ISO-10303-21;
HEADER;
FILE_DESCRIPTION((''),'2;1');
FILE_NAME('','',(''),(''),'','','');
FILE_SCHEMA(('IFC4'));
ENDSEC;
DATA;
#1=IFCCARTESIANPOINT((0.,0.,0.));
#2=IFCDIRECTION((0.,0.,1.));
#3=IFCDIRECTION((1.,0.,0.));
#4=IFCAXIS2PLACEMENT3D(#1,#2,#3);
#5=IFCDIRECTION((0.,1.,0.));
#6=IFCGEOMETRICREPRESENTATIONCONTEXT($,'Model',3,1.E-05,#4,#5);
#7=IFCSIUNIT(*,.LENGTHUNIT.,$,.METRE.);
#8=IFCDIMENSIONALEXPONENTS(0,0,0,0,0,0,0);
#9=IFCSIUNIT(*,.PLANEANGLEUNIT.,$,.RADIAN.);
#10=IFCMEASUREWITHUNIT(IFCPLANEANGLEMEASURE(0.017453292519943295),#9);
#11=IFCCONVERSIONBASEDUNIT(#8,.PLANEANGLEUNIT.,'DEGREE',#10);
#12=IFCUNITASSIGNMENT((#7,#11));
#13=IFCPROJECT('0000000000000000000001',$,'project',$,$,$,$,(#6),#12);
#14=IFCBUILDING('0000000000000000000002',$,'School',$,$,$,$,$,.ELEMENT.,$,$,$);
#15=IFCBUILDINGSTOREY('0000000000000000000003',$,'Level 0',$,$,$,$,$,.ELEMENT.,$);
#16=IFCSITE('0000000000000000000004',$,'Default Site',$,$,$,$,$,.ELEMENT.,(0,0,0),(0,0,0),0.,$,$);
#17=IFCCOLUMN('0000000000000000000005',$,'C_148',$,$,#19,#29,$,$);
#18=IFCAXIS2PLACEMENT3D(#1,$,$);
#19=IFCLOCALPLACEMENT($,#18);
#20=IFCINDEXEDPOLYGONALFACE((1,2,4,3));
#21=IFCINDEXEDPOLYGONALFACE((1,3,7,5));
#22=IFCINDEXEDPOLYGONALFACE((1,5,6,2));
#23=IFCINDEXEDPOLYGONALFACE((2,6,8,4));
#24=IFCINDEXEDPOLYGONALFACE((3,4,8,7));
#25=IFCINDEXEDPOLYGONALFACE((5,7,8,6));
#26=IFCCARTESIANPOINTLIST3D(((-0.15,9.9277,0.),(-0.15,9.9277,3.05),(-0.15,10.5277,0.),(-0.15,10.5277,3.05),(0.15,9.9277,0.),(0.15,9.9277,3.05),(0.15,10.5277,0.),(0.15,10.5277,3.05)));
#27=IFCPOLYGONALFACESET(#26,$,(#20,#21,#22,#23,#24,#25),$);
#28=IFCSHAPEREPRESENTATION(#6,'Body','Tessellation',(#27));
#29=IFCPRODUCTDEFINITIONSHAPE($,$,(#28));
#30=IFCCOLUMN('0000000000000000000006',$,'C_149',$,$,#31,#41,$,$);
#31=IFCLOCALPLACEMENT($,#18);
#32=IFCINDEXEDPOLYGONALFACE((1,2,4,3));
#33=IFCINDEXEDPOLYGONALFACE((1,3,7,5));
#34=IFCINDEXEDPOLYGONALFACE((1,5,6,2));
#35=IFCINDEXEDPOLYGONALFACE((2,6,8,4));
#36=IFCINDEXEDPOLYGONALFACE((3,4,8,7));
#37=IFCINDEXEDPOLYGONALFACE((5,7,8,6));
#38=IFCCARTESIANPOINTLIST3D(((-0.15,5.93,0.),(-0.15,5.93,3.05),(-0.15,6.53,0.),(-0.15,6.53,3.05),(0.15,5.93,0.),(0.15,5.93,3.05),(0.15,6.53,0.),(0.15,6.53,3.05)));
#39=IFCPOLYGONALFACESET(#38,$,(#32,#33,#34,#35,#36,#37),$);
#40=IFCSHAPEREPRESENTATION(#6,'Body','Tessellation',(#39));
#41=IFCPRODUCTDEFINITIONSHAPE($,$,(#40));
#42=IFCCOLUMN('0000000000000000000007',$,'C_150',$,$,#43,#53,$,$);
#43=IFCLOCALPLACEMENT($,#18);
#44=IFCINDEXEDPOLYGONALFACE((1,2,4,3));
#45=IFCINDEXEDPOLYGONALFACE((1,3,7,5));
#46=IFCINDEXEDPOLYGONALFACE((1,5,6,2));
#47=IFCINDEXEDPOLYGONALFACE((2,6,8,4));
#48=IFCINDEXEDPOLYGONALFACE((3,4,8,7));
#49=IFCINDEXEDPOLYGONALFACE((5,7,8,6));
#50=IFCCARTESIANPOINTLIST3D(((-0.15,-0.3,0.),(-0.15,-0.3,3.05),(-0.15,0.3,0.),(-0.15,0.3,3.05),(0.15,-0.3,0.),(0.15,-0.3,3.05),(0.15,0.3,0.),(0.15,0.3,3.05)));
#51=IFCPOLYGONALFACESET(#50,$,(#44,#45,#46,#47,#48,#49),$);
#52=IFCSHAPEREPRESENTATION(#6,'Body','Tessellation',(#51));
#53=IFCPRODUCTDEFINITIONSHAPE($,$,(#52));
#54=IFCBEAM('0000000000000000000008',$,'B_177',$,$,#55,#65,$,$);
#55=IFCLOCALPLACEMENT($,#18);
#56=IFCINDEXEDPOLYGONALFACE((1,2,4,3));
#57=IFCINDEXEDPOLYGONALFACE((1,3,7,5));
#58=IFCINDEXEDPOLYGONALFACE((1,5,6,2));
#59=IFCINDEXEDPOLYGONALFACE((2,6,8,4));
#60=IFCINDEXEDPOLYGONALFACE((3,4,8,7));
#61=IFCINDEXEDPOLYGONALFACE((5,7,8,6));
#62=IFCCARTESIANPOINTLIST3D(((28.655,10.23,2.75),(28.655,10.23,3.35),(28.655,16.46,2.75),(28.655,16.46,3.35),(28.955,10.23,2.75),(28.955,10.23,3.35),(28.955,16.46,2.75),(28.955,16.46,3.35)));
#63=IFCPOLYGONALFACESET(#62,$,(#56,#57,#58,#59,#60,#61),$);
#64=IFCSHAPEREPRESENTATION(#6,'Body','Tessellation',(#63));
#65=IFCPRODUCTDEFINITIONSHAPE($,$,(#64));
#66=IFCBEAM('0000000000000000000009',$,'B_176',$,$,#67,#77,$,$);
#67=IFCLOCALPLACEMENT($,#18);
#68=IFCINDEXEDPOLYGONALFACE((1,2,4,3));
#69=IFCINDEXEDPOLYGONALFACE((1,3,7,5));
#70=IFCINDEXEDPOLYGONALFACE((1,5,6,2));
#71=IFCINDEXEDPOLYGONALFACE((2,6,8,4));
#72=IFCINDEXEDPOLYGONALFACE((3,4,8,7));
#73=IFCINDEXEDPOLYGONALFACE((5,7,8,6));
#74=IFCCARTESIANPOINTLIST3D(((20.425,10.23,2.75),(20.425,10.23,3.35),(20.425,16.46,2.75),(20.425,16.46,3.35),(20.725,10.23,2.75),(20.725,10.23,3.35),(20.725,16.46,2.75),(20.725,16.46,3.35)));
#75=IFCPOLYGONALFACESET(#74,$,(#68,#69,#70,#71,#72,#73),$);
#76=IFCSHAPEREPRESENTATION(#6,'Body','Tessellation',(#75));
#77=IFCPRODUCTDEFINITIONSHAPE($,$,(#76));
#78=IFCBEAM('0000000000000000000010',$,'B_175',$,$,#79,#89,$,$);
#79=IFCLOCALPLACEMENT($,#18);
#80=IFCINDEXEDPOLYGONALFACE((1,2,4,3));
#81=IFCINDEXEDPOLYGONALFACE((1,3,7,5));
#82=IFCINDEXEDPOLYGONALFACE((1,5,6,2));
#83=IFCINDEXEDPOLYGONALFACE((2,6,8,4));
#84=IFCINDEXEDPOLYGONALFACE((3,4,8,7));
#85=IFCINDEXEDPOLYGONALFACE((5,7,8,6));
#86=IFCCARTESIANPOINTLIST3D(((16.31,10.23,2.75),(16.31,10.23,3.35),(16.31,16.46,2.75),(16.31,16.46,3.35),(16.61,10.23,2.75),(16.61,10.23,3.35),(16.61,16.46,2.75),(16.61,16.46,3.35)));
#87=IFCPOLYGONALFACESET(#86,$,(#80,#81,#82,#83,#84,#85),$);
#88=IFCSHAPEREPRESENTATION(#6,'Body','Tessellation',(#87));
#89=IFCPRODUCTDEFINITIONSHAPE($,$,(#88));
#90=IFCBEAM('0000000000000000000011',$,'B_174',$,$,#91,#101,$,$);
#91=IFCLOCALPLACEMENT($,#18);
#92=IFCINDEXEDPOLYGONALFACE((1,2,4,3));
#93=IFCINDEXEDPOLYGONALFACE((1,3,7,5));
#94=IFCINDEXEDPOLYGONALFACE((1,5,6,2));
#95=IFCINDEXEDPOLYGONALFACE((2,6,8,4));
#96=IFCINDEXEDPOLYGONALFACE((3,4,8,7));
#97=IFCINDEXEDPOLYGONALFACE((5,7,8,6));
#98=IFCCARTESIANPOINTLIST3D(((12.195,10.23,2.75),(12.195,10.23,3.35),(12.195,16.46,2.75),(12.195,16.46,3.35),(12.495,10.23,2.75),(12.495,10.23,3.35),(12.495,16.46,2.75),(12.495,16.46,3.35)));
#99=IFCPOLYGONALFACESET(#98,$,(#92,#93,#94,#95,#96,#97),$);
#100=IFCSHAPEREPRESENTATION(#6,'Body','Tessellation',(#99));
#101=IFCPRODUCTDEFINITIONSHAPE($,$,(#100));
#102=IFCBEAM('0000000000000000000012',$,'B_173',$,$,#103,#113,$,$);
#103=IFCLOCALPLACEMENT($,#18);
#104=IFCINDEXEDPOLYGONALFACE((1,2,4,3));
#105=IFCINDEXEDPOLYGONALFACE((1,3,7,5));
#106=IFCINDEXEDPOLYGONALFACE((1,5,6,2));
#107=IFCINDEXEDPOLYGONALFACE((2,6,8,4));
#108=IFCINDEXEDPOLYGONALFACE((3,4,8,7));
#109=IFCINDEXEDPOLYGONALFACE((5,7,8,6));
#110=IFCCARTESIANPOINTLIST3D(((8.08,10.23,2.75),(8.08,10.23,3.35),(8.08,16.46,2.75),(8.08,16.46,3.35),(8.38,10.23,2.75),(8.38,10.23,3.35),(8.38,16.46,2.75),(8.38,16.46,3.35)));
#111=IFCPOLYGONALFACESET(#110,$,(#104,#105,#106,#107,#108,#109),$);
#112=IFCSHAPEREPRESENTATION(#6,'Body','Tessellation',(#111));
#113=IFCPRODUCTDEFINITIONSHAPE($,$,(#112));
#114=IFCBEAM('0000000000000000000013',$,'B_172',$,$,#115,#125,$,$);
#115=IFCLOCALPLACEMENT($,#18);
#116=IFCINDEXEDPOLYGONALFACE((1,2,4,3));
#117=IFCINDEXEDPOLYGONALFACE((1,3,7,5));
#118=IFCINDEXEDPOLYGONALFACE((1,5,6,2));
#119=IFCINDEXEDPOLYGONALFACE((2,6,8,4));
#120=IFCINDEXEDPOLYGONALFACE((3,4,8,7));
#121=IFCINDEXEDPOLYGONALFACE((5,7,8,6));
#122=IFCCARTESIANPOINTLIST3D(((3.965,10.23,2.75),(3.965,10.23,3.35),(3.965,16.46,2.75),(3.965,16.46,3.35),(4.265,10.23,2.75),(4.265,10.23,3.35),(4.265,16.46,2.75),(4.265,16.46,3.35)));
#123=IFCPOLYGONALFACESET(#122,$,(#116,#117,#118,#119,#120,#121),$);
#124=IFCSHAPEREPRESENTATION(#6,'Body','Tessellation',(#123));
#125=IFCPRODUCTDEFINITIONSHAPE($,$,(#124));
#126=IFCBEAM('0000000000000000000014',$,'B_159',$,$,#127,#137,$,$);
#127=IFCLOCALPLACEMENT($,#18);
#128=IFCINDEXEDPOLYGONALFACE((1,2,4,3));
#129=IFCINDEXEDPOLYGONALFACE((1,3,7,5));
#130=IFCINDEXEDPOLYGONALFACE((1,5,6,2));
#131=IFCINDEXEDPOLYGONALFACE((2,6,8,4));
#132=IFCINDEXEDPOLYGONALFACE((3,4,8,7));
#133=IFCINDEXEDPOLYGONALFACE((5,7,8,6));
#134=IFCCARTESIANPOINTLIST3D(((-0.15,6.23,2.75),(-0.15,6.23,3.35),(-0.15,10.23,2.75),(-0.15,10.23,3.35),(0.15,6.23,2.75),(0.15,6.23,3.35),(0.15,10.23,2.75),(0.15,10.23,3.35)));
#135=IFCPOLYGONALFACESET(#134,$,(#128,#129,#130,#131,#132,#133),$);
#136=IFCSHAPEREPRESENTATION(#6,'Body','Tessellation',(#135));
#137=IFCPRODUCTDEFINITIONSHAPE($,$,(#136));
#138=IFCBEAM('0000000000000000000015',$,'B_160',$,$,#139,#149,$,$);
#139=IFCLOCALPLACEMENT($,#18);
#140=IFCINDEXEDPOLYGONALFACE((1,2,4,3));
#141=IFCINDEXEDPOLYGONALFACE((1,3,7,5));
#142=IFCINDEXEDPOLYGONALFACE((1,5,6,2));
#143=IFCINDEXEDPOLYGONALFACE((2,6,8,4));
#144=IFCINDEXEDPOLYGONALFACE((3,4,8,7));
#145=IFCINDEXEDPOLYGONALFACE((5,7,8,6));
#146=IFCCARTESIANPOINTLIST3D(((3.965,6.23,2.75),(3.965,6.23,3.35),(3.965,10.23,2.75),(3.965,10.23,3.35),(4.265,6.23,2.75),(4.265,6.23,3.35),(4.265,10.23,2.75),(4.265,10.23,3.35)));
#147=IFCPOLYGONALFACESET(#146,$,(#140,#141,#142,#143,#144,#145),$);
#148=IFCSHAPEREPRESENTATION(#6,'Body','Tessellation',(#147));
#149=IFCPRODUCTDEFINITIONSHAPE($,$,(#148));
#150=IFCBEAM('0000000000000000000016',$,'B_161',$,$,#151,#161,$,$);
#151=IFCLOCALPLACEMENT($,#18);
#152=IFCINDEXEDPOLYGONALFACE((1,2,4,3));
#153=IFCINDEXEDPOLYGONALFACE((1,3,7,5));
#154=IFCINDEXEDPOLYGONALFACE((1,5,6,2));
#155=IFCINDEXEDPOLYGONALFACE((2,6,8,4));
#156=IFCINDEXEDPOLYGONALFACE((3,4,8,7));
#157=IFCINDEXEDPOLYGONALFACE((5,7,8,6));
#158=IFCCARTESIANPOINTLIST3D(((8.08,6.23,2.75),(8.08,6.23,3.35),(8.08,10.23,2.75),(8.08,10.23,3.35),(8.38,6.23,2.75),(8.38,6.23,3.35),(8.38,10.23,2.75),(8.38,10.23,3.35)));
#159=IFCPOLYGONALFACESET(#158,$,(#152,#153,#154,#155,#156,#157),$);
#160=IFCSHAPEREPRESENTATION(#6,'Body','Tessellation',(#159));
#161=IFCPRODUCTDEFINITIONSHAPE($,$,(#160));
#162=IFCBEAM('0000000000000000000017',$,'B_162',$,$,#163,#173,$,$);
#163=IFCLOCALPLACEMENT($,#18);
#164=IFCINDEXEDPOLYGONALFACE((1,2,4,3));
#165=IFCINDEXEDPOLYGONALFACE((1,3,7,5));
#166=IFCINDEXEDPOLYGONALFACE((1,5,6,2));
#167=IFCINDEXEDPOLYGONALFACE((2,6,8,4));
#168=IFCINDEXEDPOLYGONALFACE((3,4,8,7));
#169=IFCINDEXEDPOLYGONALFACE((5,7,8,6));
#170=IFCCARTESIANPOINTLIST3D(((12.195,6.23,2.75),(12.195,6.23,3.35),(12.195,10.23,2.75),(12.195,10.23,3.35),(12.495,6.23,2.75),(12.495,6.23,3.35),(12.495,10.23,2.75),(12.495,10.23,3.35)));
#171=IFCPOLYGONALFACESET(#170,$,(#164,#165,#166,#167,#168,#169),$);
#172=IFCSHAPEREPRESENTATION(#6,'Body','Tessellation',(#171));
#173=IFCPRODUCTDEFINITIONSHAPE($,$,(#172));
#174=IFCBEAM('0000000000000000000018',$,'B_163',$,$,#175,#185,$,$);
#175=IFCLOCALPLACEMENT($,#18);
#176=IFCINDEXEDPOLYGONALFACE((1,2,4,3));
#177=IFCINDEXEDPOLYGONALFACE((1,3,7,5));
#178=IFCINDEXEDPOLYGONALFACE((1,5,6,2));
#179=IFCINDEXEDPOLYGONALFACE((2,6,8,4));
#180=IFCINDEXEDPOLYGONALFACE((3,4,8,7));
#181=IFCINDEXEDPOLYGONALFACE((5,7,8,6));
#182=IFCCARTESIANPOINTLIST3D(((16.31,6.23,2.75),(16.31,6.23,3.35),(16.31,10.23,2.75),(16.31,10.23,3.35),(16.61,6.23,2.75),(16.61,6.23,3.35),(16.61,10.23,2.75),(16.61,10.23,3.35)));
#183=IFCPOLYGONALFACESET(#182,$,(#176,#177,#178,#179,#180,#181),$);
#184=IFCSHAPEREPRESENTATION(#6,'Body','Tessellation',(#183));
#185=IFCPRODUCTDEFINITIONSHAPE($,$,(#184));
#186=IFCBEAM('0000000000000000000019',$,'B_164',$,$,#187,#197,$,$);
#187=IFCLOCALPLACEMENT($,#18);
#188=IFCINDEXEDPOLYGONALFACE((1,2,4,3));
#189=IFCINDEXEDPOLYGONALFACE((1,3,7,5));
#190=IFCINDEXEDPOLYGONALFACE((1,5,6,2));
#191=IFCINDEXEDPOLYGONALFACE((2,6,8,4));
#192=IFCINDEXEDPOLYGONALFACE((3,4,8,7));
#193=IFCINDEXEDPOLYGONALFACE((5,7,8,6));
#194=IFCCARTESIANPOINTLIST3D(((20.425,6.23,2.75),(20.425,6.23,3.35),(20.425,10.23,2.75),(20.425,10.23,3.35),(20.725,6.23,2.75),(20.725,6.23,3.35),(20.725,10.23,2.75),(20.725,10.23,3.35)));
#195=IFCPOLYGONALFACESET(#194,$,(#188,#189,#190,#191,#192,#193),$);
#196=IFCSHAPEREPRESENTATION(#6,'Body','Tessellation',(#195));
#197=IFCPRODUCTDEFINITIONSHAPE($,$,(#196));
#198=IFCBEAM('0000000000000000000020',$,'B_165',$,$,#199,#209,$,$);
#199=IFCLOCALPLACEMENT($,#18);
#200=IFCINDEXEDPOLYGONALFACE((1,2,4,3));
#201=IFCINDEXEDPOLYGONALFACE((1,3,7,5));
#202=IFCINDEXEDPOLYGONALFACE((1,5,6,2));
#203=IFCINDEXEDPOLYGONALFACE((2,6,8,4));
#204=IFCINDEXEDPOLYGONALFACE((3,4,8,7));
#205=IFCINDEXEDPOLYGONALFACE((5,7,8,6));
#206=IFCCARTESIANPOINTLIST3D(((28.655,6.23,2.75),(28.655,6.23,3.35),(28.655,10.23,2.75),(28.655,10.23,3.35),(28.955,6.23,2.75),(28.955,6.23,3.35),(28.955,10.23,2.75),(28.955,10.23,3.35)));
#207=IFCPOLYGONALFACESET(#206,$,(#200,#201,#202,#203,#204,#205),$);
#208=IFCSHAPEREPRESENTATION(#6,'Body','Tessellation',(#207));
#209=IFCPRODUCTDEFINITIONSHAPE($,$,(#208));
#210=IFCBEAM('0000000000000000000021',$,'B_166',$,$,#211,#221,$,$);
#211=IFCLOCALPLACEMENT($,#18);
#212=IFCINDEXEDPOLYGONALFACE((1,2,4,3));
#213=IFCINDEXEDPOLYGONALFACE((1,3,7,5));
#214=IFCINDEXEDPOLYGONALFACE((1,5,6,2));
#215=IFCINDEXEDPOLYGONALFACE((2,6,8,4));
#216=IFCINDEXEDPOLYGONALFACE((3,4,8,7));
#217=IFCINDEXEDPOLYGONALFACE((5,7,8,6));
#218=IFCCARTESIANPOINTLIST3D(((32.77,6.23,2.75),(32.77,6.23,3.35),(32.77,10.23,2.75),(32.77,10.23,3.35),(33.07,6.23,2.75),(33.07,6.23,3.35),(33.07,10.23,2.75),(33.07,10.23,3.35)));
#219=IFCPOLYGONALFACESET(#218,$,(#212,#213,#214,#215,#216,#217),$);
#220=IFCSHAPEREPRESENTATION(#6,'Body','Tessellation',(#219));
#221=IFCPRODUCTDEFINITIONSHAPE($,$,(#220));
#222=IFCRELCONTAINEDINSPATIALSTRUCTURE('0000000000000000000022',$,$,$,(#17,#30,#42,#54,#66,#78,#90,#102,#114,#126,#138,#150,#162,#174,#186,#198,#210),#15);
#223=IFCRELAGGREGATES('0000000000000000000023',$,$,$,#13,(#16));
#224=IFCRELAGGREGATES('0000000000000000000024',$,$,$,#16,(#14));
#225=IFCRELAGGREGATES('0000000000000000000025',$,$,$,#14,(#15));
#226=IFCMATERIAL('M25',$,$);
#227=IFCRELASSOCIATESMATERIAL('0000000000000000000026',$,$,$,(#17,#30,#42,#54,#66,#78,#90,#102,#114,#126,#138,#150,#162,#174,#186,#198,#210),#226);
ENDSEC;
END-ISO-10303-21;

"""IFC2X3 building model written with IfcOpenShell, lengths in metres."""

from ifc_helpers import new_model, entity, si_unit, converted_unit, direction, frame, frame_2d, origin_with_axes, place, context, project, spatial, rectangle, extrude, material, element, save


model = new_model("IFC2X3")

# Units and contexts
model_context = context("Model", 3, precision=1e-05, world=origin_with_axes(), true_north=direction((0.0, 1.0, 0.0)))
ifc_project = project(units=[si_unit("LENGTHUNIT", "METRE"), converted_unit("PLANEANGLEUNIT", "DEGREE", entity("IfcPlaneAngleMeasure", 0.017453292519943295), si_unit("PLANEANGLEUNIT", "RADIAN"), dimensions=[0, 0, 0, 0, 0, 0, 0])], contexts=[model_context])

# Site, building, storey
site = spatial("IfcSite", under=ifc_project, Name="Default Site", CompositionType="ELEMENT", RefLatitude=(0, 0, 0), RefLongitude=(0, 0, 0), RefElevation=0.0)
building = spatial("IfcBuilding", under=site, Name="School", CompositionType="ELEMENT")
storey = spatial("IfcBuildingStorey", under=building, Name="Level 0", CompositionType="ELEMENT")

# Columns
ifc_material = material(Name="M25")
placement = place(None, origin_with_axes())
element("IfcColumn", 1, at=placement, inside=storey, material=ifc_material, Name="C_148", context=model_context, shape_type="SweptSolid", body=[
    extrude(rectangle(XDim=0.3, YDim=0.6, at=frame_2d((0.0, 0.0), x_axis=(1.0, 0.0, 0.0))), frame((0.0, 10.2277, 0.0), z_axis=(0.0, 0.0, 1.0), x_axis=(1.0, 0.0, 0.0)), (0.0, 0.0, 1.0), 3.05),
])
element("IfcColumn", 2, at=placement, inside=storey, material=ifc_material, Name="C_149", context=model_context, shape_type="SweptSolid", body=[
    extrude(rectangle(XDim=0.3, YDim=0.6, at=frame_2d((0.0, 0.0), x_axis=(1.0, 0.0, 0.0))), frame((0.0, 6.23, 0.0), z_axis=(0.0, 0.0, 1.0), x_axis=(1.0, 0.0, 0.0)), (0.0, 0.0, 1.0), 3.05),
])
element("IfcColumn", 3, at=placement, inside=storey, material=ifc_material, Name="C_150", context=model_context, shape_type="SweptSolid", body=[
    extrude(rectangle(XDim=0.3, YDim=0.6, at=frame_2d((0.0, 0.0), x_axis=(1.0, 0.0, 0.0))), frame((0.0, 0.0, 0.0), z_axis=(0.0, 0.0, 1.0), x_axis=(1.0, 0.0, 0.0)), (0.0, 0.0, 1.0), 3.05),
])

# Beams
element("IfcBeam", 4, at=placement, inside=storey, material=ifc_material, Name="B_177", context=model_context, shape_type="SweptSolid", body=[
    extrude(rectangle(XDim=0.3, YDim=0.6, at=frame_2d((0.0, 0.0), x_axis=(0.0, 1.0, 0.0))), frame((28.805, 10.23, 3.05), z_axis=(0.0, 1.0, 0.0), x_axis=(0.0, 0.0, -1.0)), (0.0, 0.0, 1.0), 6.23),
])
element("IfcBeam", 5, at=placement, inside=storey, material=ifc_material, Name="B_176", context=model_context, shape_type="SweptSolid", body=[
    extrude(rectangle(XDim=0.3, YDim=0.6, at=frame_2d((0.0, 0.0), x_axis=(0.0, 1.0, 0.0))), frame((20.575, 10.23, 3.05), z_axis=(0.0, 1.0, 0.0), x_axis=(0.0, 0.0, -1.0)), (0.0, 0.0, 1.0), 6.23),
])
element("IfcBeam", 6, at=placement, inside=storey, material=ifc_material, Name="B_175", context=model_context, shape_type="SweptSolid", body=[
    extrude(rectangle(XDim=0.3, YDim=0.6, at=frame_2d((0.0, 0.0), x_axis=(0.0, 1.0, 0.0))), frame((16.46, 10.23, 3.05), z_axis=(0.0, 1.0, 0.0), x_axis=(0.0, 0.0, -1.0)), (0.0, 0.0, 1.0), 6.23),
])
element("IfcBeam", 7, at=placement, inside=storey, material=ifc_material, Name="B_174", context=model_context, shape_type="SweptSolid", body=[
    extrude(rectangle(XDim=0.3, YDim=0.6, at=frame_2d((0.0, 0.0), x_axis=(0.0, 1.0, 0.0))), frame((12.345, 10.23, 3.05), z_axis=(0.0, 1.0, 0.0), x_axis=(0.0, 0.0, -1.0)), (0.0, 0.0, 1.0), 6.23),
])
element("IfcBeam", 8, at=placement, inside=storey, material=ifc_material, Name="B_173", context=model_context, shape_type="SweptSolid", body=[
    extrude(rectangle(XDim=0.3, YDim=0.6, at=frame_2d((0.0, 0.0), x_axis=(0.0, 1.0, 0.0))), frame((8.23, 10.23, 3.05), z_axis=(0.0, 1.0, 0.0), x_axis=(0.0, 0.0, -1.0)), (0.0, 0.0, 1.0), 6.23),
])
element("IfcBeam", 9, at=placement, inside=storey, material=ifc_material, Name="B_172", context=model_context, shape_type="SweptSolid", body=[
    extrude(rectangle(XDim=0.3, YDim=0.6, at=frame_2d((0.0, 0.0), x_axis=(0.0, 1.0, 0.0))), frame((4.115, 10.23, 3.05), z_axis=(0.0, 1.0, 0.0), x_axis=(0.0, 0.0, -1.0)), (0.0, 0.0, 1.0), 6.23),
])
element("IfcBeam", 10, at=placement, inside=storey, material=ifc_material, Name="B_159", context=model_context, shape_type="SweptSolid", body=[
    extrude(rectangle(XDim=0.3, YDim=0.6, at=frame_2d((0.0, 0.0), x_axis=(0.0, 1.0, 0.0))), frame((0.0, 6.23, 3.05), z_axis=(0.0, 1.0, 0.0), x_axis=(0.0, 0.0, -1.0)), (0.0, 0.0, 1.0), 4.0),
])
element("IfcBeam", 11, at=placement, inside=storey, material=ifc_material, Name="B_160", context=model_context, shape_type="SweptSolid", body=[
    extrude(rectangle(XDim=0.3, YDim=0.6, at=frame_2d((0.0, 0.0), x_axis=(0.0, 1.0, 0.0))), frame((4.115, 6.23, 3.05), z_axis=(0.0, 1.0, 0.0), x_axis=(0.0, 0.0, -1.0)), (0.0, 0.0, 1.0), 4.0),
])
element("IfcBeam", 12, at=placement, inside=storey, material=ifc_material, Name="B_161", context=model_context, shape_type="SweptSolid", body=[
    extrude(rectangle(XDim=0.3, YDim=0.6, at=frame_2d((0.0, 0.0), x_axis=(0.0, 1.0, 0.0))), frame((8.23, 6.23, 3.05), z_axis=(0.0, 1.0, 0.0), x_axis=(0.0, 0.0, -1.0)), (0.0, 0.0, 1.0), 4.0),
])
element("IfcBeam", 13, at=placement, inside=storey, material=ifc_material, Name="B_162", context=model_context, shape_type="SweptSolid", body=[
    extrude(rectangle(XDim=0.3, YDim=0.6, at=frame_2d((0.0, 0.0), x_axis=(0.0, 1.0, 0.0))), frame((12.345, 6.23, 3.05), z_axis=(0.0, 1.0, 0.0), x_axis=(0.0, 0.0, -1.0)), (0.0, 0.0, 1.0), 4.0),
])
element("IfcBeam", 14, at=placement, inside=storey, material=ifc_material, Name="B_163", context=model_context, shape_type="SweptSolid", body=[
    extrude(rectangle(XDim=0.3, YDim=0.6, at=frame_2d((0.0, 0.0), x_axis=(0.0, 1.0, 0.0))), frame((16.46, 6.23, 3.05), z_axis=(0.0, 1.0, 0.0), x_axis=(0.0, 0.0, -1.0)), (0.0, 0.0, 1.0), 4.0),
])
element("IfcBeam", 15, at=placement, inside=storey, material=ifc_material, Name="B_164", context=model_context, shape_type="SweptSolid", body=[
    extrude(rectangle(XDim=0.3, YDim=0.6, at=frame_2d((0.0, 0.0), x_axis=(0.0, 1.0, 0.0))), frame((20.575, 6.23, 3.05), z_axis=(0.0, 1.0, 0.0), x_axis=(0.0, 0.0, -1.0)), (0.0, 0.0, 1.0), 4.0),
])
element("IfcBeam", 16, at=placement, inside=storey, material=ifc_material, Name="B_165", context=model_context, shape_type="SweptSolid", body=[
    extrude(rectangle(XDim=0.3, YDim=0.6, at=frame_2d((0.0, 0.0), x_axis=(0.0, 1.0, 0.0))), frame((28.805, 6.23, 3.05), z_axis=(0.0, 1.0, 0.0), x_axis=(0.0, 0.0, -1.0)), (0.0, 0.0, 1.0), 4.0),
])
element("IfcBeam", 17, at=placement, inside=storey, material=ifc_material, Name="B_166", context=model_context, shape_type="SweptSolid", body=[
    extrude(rectangle(XDim=0.3, YDim=0.6, at=frame_2d((0.0, 0.0), x_axis=(0.0, 1.0, 0.0))), frame((32.92, 6.23, 3.05), z_axis=(0.0, 1.0, 0.0), x_axis=(0.0, 0.0, -1.0)), (0.0, 0.0, 1.0), 4.0),
])

save(model, "model.ifc")
